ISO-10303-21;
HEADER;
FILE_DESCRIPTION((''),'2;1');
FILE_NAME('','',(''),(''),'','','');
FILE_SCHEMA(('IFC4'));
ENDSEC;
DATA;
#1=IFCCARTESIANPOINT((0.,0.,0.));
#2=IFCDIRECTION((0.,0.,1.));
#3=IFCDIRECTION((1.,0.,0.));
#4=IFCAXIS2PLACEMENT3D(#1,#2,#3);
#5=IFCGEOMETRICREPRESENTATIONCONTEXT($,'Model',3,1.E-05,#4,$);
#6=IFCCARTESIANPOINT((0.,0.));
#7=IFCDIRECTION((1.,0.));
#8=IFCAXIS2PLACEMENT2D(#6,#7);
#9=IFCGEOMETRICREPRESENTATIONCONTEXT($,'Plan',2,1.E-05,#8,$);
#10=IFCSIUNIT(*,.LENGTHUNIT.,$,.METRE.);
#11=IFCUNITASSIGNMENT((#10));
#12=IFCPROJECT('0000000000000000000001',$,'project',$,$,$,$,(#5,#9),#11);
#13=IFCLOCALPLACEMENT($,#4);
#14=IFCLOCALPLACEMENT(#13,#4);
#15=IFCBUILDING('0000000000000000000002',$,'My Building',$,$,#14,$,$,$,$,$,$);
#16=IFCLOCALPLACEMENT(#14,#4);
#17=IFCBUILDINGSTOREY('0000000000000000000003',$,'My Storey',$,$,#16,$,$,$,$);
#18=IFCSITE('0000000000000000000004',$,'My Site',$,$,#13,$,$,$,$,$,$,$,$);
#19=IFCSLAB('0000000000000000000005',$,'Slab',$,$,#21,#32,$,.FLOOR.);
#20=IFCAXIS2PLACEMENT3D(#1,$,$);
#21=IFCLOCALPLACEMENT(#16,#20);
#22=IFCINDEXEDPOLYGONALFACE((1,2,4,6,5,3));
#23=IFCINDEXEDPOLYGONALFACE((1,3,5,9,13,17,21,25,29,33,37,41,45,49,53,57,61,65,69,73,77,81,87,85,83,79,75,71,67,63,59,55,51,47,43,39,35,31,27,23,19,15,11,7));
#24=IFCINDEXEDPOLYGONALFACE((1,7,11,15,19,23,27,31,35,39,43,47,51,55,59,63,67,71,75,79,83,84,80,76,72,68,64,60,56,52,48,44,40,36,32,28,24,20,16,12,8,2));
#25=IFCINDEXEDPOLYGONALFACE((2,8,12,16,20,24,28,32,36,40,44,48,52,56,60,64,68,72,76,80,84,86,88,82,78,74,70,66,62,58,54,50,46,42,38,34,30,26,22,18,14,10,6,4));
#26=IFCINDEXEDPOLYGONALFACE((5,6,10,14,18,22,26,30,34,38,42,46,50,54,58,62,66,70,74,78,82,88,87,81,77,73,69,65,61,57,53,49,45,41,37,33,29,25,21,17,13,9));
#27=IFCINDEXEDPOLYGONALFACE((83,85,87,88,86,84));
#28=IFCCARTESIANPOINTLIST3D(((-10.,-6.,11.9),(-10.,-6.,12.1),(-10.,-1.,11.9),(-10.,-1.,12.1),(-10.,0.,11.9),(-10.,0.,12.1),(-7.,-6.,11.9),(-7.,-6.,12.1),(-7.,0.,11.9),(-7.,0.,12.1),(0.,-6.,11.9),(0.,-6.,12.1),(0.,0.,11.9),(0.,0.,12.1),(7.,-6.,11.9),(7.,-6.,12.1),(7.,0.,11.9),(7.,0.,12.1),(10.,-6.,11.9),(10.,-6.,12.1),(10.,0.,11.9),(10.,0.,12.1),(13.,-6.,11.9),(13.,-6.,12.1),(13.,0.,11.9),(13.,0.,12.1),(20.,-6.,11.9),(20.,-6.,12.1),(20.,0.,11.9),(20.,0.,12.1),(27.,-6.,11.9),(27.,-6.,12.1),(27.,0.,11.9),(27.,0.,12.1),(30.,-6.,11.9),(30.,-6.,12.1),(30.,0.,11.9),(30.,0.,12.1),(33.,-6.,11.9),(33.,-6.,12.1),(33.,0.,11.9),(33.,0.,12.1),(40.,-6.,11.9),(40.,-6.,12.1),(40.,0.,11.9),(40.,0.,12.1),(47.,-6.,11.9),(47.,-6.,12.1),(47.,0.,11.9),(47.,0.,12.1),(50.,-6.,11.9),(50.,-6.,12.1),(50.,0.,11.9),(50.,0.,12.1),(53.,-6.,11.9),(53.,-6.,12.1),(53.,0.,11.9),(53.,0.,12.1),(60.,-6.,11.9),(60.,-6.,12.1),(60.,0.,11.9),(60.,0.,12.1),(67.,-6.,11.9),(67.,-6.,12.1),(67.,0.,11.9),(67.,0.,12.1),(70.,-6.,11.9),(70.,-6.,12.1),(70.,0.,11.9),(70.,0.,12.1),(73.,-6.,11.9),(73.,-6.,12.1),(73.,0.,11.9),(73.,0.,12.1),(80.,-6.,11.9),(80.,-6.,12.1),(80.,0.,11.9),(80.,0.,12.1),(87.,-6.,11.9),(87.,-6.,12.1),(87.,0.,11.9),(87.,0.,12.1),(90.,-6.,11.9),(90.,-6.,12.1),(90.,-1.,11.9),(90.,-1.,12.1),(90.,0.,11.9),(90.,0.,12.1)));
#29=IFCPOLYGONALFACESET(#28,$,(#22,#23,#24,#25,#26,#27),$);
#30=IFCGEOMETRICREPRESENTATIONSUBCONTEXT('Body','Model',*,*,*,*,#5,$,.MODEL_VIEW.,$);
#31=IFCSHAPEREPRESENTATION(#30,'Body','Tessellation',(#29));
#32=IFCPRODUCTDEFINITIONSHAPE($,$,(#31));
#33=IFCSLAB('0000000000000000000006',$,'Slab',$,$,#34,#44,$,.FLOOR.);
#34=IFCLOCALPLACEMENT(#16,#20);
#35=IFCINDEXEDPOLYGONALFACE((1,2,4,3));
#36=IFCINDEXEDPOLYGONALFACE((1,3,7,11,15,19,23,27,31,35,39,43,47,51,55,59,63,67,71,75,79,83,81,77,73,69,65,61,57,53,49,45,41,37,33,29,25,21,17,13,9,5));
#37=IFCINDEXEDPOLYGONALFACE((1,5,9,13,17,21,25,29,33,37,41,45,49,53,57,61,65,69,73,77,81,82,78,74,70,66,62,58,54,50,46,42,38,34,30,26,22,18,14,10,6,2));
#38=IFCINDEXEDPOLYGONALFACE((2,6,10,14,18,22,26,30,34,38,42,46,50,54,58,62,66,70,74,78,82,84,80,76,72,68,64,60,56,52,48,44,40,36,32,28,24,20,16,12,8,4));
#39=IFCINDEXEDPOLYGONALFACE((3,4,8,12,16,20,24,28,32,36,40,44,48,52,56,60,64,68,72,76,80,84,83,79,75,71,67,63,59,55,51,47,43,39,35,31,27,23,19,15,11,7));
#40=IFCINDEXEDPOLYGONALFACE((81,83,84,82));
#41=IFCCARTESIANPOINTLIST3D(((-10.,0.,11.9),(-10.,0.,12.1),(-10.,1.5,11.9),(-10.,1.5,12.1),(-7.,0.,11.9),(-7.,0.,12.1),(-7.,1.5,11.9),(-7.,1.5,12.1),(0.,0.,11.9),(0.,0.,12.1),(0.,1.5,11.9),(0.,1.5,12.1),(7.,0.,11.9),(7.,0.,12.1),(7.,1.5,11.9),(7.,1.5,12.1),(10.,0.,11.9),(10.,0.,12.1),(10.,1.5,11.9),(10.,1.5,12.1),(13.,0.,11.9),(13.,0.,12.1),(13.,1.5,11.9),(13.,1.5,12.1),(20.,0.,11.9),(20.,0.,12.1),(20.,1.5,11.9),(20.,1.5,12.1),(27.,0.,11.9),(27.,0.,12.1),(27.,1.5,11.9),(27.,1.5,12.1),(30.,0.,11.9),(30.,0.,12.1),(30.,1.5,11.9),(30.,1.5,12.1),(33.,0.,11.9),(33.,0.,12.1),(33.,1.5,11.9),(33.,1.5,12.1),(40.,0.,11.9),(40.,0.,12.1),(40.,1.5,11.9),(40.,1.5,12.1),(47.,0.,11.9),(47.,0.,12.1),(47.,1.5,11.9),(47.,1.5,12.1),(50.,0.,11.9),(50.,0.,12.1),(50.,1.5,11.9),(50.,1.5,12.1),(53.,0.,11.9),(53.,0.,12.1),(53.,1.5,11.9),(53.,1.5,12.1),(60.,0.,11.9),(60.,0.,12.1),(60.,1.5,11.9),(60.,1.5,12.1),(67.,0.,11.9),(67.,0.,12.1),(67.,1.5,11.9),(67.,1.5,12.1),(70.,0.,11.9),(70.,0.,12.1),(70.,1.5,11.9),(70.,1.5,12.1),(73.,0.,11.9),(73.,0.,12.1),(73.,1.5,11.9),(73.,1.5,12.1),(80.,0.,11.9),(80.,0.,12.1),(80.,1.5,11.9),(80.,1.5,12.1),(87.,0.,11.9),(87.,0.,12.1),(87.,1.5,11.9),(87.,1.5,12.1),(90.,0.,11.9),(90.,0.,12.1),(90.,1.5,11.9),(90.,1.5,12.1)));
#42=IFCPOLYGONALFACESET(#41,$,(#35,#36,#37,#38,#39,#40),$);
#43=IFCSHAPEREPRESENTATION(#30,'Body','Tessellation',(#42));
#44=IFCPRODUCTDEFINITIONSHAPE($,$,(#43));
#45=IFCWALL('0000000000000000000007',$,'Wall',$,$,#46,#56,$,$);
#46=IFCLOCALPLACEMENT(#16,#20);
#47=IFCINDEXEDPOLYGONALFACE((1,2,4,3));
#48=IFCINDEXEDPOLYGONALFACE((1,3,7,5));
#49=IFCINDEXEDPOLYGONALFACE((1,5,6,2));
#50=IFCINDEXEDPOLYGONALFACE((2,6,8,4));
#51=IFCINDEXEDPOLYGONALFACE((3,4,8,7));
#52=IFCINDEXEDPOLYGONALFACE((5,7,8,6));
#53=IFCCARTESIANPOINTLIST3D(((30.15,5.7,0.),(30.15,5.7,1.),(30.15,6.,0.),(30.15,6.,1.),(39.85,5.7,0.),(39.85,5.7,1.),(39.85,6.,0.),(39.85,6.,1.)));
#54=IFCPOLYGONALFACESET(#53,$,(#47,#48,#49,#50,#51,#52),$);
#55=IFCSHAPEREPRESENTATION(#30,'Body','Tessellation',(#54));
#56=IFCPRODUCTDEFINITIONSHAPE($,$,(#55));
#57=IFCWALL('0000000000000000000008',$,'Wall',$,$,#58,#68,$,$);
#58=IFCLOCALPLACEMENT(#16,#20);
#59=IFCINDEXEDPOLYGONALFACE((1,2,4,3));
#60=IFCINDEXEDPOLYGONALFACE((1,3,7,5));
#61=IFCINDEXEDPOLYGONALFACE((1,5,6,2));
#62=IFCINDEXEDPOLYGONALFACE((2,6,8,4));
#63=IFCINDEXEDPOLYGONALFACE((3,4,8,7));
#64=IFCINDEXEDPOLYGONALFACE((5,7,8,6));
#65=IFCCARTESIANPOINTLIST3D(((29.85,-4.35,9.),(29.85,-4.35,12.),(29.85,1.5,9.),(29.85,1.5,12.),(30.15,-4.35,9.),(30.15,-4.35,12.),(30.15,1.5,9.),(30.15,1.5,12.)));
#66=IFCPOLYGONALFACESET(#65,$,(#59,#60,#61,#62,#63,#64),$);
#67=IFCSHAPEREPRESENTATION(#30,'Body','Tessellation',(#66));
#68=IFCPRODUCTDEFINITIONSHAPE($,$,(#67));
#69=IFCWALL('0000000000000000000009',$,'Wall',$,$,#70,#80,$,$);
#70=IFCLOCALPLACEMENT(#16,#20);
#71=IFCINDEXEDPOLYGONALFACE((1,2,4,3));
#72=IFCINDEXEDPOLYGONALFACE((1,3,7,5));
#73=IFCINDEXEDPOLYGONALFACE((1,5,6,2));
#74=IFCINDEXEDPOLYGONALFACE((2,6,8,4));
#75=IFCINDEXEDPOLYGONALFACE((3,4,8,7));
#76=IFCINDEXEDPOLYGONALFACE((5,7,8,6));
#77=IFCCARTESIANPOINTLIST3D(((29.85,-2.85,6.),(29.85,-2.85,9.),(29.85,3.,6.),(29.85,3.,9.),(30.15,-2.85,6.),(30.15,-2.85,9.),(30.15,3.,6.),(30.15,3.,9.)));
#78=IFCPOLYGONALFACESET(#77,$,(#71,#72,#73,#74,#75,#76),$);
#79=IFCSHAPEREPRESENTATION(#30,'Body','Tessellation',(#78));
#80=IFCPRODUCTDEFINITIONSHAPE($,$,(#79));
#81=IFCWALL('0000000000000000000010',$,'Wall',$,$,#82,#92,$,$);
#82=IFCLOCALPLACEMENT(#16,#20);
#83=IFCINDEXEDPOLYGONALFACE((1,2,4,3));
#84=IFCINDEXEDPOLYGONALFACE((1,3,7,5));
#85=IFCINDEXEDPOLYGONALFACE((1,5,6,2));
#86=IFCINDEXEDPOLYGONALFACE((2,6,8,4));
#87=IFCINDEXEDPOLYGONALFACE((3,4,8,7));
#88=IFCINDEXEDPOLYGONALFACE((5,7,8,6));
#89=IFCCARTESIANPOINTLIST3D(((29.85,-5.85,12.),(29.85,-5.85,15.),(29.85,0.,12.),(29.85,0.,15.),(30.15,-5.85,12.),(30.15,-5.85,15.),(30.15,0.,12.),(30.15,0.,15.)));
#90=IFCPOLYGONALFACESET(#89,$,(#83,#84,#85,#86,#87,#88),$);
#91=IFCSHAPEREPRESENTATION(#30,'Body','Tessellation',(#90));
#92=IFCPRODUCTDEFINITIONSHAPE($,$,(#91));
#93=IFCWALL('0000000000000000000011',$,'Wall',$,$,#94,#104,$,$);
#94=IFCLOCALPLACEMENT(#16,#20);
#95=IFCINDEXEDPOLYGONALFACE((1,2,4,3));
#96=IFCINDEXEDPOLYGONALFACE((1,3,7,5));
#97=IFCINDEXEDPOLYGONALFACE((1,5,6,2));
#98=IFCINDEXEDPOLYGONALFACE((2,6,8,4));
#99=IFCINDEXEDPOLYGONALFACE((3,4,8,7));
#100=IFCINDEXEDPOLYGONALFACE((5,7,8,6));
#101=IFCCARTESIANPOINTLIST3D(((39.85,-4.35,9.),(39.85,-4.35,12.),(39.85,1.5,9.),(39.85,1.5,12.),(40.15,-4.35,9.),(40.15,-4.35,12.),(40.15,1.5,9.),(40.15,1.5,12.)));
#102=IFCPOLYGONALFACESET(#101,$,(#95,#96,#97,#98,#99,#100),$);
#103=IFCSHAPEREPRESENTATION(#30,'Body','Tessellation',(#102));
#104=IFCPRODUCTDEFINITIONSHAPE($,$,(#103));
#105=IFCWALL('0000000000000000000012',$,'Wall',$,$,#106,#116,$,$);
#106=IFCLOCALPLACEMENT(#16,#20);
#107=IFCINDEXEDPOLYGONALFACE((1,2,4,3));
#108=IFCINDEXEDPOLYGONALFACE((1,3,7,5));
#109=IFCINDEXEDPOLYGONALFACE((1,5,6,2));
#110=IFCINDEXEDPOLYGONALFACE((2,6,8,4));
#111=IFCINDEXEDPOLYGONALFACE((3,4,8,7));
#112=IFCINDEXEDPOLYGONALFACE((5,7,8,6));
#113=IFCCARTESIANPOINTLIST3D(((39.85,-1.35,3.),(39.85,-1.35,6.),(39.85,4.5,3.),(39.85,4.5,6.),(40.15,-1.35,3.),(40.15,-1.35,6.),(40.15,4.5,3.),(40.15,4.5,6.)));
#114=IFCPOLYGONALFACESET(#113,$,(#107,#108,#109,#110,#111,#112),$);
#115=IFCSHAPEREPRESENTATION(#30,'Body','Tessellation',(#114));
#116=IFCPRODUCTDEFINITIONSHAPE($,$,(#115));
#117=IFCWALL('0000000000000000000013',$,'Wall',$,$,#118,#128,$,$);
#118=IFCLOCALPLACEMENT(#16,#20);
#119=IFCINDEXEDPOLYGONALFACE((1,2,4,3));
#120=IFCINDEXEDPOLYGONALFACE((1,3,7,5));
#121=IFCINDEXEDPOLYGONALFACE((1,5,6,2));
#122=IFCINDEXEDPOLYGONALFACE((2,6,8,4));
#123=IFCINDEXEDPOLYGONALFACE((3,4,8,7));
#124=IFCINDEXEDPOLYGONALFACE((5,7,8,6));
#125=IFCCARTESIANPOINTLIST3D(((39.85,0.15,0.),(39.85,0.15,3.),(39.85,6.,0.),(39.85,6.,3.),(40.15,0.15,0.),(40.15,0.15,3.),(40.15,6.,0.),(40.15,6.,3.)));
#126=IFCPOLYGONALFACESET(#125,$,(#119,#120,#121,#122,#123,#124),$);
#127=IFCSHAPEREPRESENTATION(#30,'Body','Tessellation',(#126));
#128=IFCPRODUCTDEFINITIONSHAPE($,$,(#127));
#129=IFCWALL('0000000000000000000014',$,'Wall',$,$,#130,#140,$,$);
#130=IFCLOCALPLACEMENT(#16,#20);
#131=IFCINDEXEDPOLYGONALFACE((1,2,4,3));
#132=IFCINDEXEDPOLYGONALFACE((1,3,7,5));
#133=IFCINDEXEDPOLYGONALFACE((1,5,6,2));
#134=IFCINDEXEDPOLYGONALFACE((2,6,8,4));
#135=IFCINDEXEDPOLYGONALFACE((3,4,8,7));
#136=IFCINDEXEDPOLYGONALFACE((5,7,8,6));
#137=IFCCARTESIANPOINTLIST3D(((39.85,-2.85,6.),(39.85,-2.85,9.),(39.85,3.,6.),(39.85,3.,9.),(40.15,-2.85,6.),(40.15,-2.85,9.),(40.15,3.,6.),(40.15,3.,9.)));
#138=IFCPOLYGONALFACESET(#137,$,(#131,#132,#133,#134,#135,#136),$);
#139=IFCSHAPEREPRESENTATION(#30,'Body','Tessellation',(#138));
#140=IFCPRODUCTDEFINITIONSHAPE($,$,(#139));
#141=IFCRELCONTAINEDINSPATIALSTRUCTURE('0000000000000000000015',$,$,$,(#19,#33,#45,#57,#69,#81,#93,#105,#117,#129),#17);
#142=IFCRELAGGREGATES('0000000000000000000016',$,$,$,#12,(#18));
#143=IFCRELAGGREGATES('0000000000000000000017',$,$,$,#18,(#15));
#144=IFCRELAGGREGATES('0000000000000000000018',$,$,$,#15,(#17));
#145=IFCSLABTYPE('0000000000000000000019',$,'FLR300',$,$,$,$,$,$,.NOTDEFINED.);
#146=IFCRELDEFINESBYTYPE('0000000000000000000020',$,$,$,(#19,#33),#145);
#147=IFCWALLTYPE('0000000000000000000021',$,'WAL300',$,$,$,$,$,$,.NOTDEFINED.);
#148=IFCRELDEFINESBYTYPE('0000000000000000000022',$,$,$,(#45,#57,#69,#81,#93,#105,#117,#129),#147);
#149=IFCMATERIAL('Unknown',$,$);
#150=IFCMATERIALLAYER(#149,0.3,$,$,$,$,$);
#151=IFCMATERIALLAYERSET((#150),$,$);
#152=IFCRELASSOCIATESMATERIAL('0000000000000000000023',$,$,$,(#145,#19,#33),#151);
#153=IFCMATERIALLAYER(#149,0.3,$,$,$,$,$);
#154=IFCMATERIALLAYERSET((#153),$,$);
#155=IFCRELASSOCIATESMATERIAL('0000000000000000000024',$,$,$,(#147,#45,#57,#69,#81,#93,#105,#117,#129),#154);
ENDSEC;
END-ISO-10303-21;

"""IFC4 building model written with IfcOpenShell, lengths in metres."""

from ifc_helpers import new_model, si_unit, frame, origin, origin_with_axes, origin_2d_with_axis, place, context, subcontext, project, spatial, polyline, line, indexed_curve, outline, extrude, material, layer, layer_set, layer_usage, type_object, element, save


model = new_model("IFC4")

# Units and contexts
model_context = context("Model", 3, precision=1e-05, world=origin_with_axes())
plan_context = context("Plan", 2, precision=1e-05, world=origin_2d_with_axis())
body_context = subcontext(model_context, "Body", "Model", "MODEL_VIEW")
ifc_project = project(units=[si_unit("LENGTHUNIT", "METRE")], contexts=[model_context, plan_context])

# Site, building, storey
site_placement = place(None, origin_with_axes())
site = spatial("IfcSite", under=ifc_project, at=site_placement, Name="My Site")
building_placement = place(site_placement, origin_with_axes())
building = spatial("IfcBuilding", under=site, at=building_placement, Name="My Building")
storey_placement = place(building_placement, origin_with_axes())
storey = spatial("IfcBuildingStorey", under=building, at=storey_placement, Name="My Storey")

# Slabs
ifc_material = material(Name="Unknown")
ifc_layer_1 = layer(ifc_material, 0.3)
ifc_layer_set_1 = layer_set([ifc_layer_1])
slab_type = type_object("IfcSlabType", Name="FLR300", PredefinedType="NOTDEFINED", material=ifc_layer_set_1)
ifc_layer_usage_1 = layer_usage(ifc_layer_set_1, "AXIS3", "POSITIVE", 0.0)
slab_1_placement = place(storey_placement, frame((40.0, -2.9091, 11.9), z_axis=(0.0, 0.0, 1.0), x_axis=(1.0, 0.0, 0.0)))
element("IfcSlab", 1, at=slab_1_placement, inside=storey, type_object=slab_type, material=ifc_layer_usage_1, Name="Slab", PredefinedType="FLOOR", context=body_context, shape_type="SweptSolid", body=[
    extrude(outline(polyline([(-47.0, 2.9091), (-50.0, 2.9091), (-50.0, 1.9091), (-50.0, -3.0909), (-47.0, -3.0909), (-40.0, -3.0909), (-33.0, -3.0909), (-30.0, -3.0909), (-27.0, -3.0909), (-20.0, -3.0909), (-13.0, -3.0909), (-10.0, -3.0909), (-7.0, -3.0909), (0.0, -3.0909), (7.0, -3.0909), (10.0, -3.0909), (13.0, -3.0909), (20.0, -3.0909), (27.0, -3.0909), (30.0, -3.0909), (33.0, -3.0909), (40.0, -3.0909), (47.0, -3.0909), (50.0, -3.0909), (50.0, 1.9091), (50.0, 2.9091), (47.0, 2.9091), (40.0, 2.9091), (33.0, 2.9091), (30.0, 2.9091), (27.0, 2.9091), (20.0, 2.9091), (13.0, 2.9091), (10.0, 2.9091), (7.0, 2.9091), (0.0, 2.9091), (-7.0, 2.9091), (-10.0, 2.9091), (-13.0, 2.9091), (-20.0, 2.9091), (-27.0, 2.9091), (-30.0, 2.9091), (-33.0, 2.9091), (-40.0, 2.9091), (-47.0, 2.9091)])), origin(), (0.0, 0.0, 1.0), 0.2),
])
ifc_layer_usage_2 = layer_usage(ifc_layer_set_1, "AXIS3", "POSITIVE", 0.0)
slab_2_placement = place(storey_placement, frame((40.0, 0.75, 11.9), z_axis=(0.0, 0.0, 1.0), x_axis=(1.0, 0.0, 0.0)))
element("IfcSlab", 2, at=slab_2_placement, inside=storey, type_object=slab_type, material=ifc_layer_usage_2, Name="Slab", PredefinedType="FLOOR", context=body_context, shape_type="SweptSolid", body=[
    extrude(outline(polyline([(-40.0, -0.75), (-33.0, -0.75), (-30.0, -0.75), (-27.0, -0.75), (-20.0, -0.75), (-13.0, -0.75), (-10.0, -0.75), (-7.0, -0.75), (0.0, -0.75), (7.0, -0.75), (10.0, -0.75), (13.0, -0.75), (20.0, -0.75), (27.0, -0.75), (30.0, -0.75), (33.0, -0.75), (40.0, -0.75), (47.0, -0.75), (50.0, -0.75), (50.0, 0.75), (47.0, 0.75), (40.0, 0.75), (33.0, 0.75), (30.0, 0.75), (27.0, 0.75), (20.0, 0.75), (13.0, 0.75), (10.0, 0.75), (7.0, 0.75), (0.0, 0.75), (-7.0, 0.75), (-10.0, 0.75), (-13.0, 0.75), (-20.0, 0.75), (-27.0, 0.75), (-30.0, 0.75), (-33.0, 0.75), (-40.0, 0.75), (-47.0, 0.75), (-50.0, 0.75), (-50.0, -0.75), (-47.0, -0.75), (-40.0, -0.75)])), origin(), (0.0, 0.0, 1.0), 0.2),
])

# Walls
ifc_layer_2 = layer(ifc_material, 0.3)
ifc_layer_set_2 = layer_set([ifc_layer_2])
ifc_layer_usage_3 = layer_usage(ifc_layer_set_2, "AXIS2", "POSITIVE", -0.3)
wall_type = type_object("IfcWallType", Name="WAL300", PredefinedType="NOTDEFINED", material=ifc_layer_set_2)
wall_1_placement = place(storey_placement, frame((30.15, 6.0, 0.0), z_axis=(0.0, 0.0, 1.0), x_axis=(1.0, 0.0, 0.0)))
element("IfcWall", 3, at=wall_1_placement, inside=storey, type_object=wall_type, material=ifc_layer_usage_3, Name="Wall", context=body_context, shape_type="SweptSolid", body=[
    extrude(outline(indexed_curve([(0.0, -0.3), (0.0, 0.0), (9.7, 0.0), (9.7, -0.3)], segments=[line(1, 2, 3, 4, 1)])), origin_with_axes(), (0.0, 0.0, 1.0), 1.0),
])
ifc_layer_usage_4 = layer_usage(ifc_layer_set_2, "AXIS2", "POSITIVE", -0.15)
wall_2_placement = place(storey_placement, frame((30.0, 1.5, 9.0), z_axis=(0.0, 0.0, 1.0), x_axis=(0.0, -1.0, 0.0)))
element("IfcWall", 4, at=wall_2_placement, inside=storey, type_object=wall_type, material=ifc_layer_usage_4, Name="Wall", context=body_context, shape_type="SweptSolid", body=[
    extrude(outline(indexed_curve([(0.0, -0.15), (0.0, 0.15), (5.85, 0.15), (5.85, -0.15)], segments=[line(1, 2, 3, 4, 1)])), origin_with_axes(), (0.0, 0.0, 1.0), 3.0),
])
ifc_layer_usage_5 = layer_usage(ifc_layer_set_2, "AXIS2", "POSITIVE", -0.15)
wall_3_placement = place(storey_placement, frame((30.0, 3.0, 6.0), z_axis=(0.0, 0.0, 1.0), x_axis=(0.0, -1.0, 0.0)))
element("IfcWall", 5, at=wall_3_placement, inside=storey, type_object=wall_type, material=ifc_layer_usage_5, Name="Wall", context=body_context, shape_type="SweptSolid", body=[
    extrude(outline(indexed_curve([(0.0, -0.15), (0.0, 0.15), (5.85, 0.15), (5.85, -0.15)], segments=[line(1, 2, 3, 4, 1)])), origin_with_axes(), (0.0, 0.0, 1.0), 3.0),
])
ifc_layer_usage_6 = layer_usage(ifc_layer_set_2, "AXIS2", "POSITIVE", -0.15)
wall_4_placement = place(storey_placement, frame((30.0, 0.0, 12.0), z_axis=(0.0, 0.0, 1.0), x_axis=(0.0, -1.0, 0.0)))
element("IfcWall", 6, at=wall_4_placement, inside=storey, type_object=wall_type, material=ifc_layer_usage_6, Name="Wall", context=body_context, shape_type="SweptSolid", body=[
    extrude(outline(indexed_curve([(0.0, -0.15), (0.0, 0.15), (5.85, 0.15), (5.85, -0.15)], segments=[line(1, 2, 3, 4, 1)])), origin_with_axes(), (0.0, 0.0, 1.0), 3.0),
])
ifc_layer_usage_7 = layer_usage(ifc_layer_set_2, "AXIS2", "POSITIVE", -0.15)
wall_5_placement = place(storey_placement, frame((40.0, -4.5, 9.0), z_axis=(0.0, 0.0, 1.0), x_axis=(0.0, 1.0, 0.0)))
element("IfcWall", 7, at=wall_5_placement, inside=storey, type_object=wall_type, material=ifc_layer_usage_7, Name="Wall", context=body_context, shape_type="SweptSolid", body=[
    extrude(outline(indexed_curve([(0.15, -0.15), (0.15, 0.15), (6.0, 0.15), (6.0, -0.15)], segments=[line(1, 2, 3, 4, 1)])), origin_with_axes(), (0.0, 0.0, 1.0), 3.0),
])
ifc_layer_usage_8 = layer_usage(ifc_layer_set_2, "AXIS2", "POSITIVE", -0.15)
wall_6_placement = place(storey_placement, frame((40.0, -1.5, 3.0), z_axis=(0.0, 0.0, 1.0), x_axis=(0.0, 1.0, 0.0)))
element("IfcWall", 8, at=wall_6_placement, inside=storey, type_object=wall_type, material=ifc_layer_usage_8, Name="Wall", context=body_context, shape_type="SweptSolid", body=[
    extrude(outline(indexed_curve([(0.15, -0.15), (0.15, 0.15), (6.0, 0.15), (6.0, -0.15)], segments=[line(1, 2, 3, 4, 1)])), origin_with_axes(), (0.0, 0.0, 1.0), 3.0),
])
ifc_layer_usage_9 = layer_usage(ifc_layer_set_2, "AXIS2", "POSITIVE", -0.15)
wall_7_placement = place(storey_placement, frame((40.0, 0.0, 0.0), z_axis=(0.0, 0.0, 1.0), x_axis=(0.0, 1.0, 0.0)))
element("IfcWall", 9, at=wall_7_placement, inside=storey, type_object=wall_type, material=ifc_layer_usage_9, Name="Wall", context=body_context, shape_type="SweptSolid", body=[
    extrude(outline(indexed_curve([(0.15, -0.15), (0.15, 0.15), (6.0, 0.15), (6.0, -0.15)], segments=[line(1, 2, 3, 4, 1)])), origin_with_axes(), (0.0, 0.0, 1.0), 3.0),
])
ifc_layer_usage_10 = layer_usage(ifc_layer_set_2, "AXIS2", "POSITIVE", -0.15)
wall_8_placement = place(storey_placement, frame((40.0, -3.0, 6.0), z_axis=(0.0, 0.0, 1.0), x_axis=(0.0, 1.0, 0.0)))
element("IfcWall", 10, at=wall_8_placement, inside=storey, type_object=wall_type, material=ifc_layer_usage_10, Name="Wall", context=body_context, shape_type="SweptSolid", body=[
    extrude(outline(indexed_curve([(0.15, -0.15), (0.15, 0.15), (6.0, 0.15), (6.0, -0.15)], segments=[line(1, 2, 3, 4, 1)])), origin_with_axes(), (0.0, 0.0, 1.0), 3.0),
])

save(model, "model.ifc")
